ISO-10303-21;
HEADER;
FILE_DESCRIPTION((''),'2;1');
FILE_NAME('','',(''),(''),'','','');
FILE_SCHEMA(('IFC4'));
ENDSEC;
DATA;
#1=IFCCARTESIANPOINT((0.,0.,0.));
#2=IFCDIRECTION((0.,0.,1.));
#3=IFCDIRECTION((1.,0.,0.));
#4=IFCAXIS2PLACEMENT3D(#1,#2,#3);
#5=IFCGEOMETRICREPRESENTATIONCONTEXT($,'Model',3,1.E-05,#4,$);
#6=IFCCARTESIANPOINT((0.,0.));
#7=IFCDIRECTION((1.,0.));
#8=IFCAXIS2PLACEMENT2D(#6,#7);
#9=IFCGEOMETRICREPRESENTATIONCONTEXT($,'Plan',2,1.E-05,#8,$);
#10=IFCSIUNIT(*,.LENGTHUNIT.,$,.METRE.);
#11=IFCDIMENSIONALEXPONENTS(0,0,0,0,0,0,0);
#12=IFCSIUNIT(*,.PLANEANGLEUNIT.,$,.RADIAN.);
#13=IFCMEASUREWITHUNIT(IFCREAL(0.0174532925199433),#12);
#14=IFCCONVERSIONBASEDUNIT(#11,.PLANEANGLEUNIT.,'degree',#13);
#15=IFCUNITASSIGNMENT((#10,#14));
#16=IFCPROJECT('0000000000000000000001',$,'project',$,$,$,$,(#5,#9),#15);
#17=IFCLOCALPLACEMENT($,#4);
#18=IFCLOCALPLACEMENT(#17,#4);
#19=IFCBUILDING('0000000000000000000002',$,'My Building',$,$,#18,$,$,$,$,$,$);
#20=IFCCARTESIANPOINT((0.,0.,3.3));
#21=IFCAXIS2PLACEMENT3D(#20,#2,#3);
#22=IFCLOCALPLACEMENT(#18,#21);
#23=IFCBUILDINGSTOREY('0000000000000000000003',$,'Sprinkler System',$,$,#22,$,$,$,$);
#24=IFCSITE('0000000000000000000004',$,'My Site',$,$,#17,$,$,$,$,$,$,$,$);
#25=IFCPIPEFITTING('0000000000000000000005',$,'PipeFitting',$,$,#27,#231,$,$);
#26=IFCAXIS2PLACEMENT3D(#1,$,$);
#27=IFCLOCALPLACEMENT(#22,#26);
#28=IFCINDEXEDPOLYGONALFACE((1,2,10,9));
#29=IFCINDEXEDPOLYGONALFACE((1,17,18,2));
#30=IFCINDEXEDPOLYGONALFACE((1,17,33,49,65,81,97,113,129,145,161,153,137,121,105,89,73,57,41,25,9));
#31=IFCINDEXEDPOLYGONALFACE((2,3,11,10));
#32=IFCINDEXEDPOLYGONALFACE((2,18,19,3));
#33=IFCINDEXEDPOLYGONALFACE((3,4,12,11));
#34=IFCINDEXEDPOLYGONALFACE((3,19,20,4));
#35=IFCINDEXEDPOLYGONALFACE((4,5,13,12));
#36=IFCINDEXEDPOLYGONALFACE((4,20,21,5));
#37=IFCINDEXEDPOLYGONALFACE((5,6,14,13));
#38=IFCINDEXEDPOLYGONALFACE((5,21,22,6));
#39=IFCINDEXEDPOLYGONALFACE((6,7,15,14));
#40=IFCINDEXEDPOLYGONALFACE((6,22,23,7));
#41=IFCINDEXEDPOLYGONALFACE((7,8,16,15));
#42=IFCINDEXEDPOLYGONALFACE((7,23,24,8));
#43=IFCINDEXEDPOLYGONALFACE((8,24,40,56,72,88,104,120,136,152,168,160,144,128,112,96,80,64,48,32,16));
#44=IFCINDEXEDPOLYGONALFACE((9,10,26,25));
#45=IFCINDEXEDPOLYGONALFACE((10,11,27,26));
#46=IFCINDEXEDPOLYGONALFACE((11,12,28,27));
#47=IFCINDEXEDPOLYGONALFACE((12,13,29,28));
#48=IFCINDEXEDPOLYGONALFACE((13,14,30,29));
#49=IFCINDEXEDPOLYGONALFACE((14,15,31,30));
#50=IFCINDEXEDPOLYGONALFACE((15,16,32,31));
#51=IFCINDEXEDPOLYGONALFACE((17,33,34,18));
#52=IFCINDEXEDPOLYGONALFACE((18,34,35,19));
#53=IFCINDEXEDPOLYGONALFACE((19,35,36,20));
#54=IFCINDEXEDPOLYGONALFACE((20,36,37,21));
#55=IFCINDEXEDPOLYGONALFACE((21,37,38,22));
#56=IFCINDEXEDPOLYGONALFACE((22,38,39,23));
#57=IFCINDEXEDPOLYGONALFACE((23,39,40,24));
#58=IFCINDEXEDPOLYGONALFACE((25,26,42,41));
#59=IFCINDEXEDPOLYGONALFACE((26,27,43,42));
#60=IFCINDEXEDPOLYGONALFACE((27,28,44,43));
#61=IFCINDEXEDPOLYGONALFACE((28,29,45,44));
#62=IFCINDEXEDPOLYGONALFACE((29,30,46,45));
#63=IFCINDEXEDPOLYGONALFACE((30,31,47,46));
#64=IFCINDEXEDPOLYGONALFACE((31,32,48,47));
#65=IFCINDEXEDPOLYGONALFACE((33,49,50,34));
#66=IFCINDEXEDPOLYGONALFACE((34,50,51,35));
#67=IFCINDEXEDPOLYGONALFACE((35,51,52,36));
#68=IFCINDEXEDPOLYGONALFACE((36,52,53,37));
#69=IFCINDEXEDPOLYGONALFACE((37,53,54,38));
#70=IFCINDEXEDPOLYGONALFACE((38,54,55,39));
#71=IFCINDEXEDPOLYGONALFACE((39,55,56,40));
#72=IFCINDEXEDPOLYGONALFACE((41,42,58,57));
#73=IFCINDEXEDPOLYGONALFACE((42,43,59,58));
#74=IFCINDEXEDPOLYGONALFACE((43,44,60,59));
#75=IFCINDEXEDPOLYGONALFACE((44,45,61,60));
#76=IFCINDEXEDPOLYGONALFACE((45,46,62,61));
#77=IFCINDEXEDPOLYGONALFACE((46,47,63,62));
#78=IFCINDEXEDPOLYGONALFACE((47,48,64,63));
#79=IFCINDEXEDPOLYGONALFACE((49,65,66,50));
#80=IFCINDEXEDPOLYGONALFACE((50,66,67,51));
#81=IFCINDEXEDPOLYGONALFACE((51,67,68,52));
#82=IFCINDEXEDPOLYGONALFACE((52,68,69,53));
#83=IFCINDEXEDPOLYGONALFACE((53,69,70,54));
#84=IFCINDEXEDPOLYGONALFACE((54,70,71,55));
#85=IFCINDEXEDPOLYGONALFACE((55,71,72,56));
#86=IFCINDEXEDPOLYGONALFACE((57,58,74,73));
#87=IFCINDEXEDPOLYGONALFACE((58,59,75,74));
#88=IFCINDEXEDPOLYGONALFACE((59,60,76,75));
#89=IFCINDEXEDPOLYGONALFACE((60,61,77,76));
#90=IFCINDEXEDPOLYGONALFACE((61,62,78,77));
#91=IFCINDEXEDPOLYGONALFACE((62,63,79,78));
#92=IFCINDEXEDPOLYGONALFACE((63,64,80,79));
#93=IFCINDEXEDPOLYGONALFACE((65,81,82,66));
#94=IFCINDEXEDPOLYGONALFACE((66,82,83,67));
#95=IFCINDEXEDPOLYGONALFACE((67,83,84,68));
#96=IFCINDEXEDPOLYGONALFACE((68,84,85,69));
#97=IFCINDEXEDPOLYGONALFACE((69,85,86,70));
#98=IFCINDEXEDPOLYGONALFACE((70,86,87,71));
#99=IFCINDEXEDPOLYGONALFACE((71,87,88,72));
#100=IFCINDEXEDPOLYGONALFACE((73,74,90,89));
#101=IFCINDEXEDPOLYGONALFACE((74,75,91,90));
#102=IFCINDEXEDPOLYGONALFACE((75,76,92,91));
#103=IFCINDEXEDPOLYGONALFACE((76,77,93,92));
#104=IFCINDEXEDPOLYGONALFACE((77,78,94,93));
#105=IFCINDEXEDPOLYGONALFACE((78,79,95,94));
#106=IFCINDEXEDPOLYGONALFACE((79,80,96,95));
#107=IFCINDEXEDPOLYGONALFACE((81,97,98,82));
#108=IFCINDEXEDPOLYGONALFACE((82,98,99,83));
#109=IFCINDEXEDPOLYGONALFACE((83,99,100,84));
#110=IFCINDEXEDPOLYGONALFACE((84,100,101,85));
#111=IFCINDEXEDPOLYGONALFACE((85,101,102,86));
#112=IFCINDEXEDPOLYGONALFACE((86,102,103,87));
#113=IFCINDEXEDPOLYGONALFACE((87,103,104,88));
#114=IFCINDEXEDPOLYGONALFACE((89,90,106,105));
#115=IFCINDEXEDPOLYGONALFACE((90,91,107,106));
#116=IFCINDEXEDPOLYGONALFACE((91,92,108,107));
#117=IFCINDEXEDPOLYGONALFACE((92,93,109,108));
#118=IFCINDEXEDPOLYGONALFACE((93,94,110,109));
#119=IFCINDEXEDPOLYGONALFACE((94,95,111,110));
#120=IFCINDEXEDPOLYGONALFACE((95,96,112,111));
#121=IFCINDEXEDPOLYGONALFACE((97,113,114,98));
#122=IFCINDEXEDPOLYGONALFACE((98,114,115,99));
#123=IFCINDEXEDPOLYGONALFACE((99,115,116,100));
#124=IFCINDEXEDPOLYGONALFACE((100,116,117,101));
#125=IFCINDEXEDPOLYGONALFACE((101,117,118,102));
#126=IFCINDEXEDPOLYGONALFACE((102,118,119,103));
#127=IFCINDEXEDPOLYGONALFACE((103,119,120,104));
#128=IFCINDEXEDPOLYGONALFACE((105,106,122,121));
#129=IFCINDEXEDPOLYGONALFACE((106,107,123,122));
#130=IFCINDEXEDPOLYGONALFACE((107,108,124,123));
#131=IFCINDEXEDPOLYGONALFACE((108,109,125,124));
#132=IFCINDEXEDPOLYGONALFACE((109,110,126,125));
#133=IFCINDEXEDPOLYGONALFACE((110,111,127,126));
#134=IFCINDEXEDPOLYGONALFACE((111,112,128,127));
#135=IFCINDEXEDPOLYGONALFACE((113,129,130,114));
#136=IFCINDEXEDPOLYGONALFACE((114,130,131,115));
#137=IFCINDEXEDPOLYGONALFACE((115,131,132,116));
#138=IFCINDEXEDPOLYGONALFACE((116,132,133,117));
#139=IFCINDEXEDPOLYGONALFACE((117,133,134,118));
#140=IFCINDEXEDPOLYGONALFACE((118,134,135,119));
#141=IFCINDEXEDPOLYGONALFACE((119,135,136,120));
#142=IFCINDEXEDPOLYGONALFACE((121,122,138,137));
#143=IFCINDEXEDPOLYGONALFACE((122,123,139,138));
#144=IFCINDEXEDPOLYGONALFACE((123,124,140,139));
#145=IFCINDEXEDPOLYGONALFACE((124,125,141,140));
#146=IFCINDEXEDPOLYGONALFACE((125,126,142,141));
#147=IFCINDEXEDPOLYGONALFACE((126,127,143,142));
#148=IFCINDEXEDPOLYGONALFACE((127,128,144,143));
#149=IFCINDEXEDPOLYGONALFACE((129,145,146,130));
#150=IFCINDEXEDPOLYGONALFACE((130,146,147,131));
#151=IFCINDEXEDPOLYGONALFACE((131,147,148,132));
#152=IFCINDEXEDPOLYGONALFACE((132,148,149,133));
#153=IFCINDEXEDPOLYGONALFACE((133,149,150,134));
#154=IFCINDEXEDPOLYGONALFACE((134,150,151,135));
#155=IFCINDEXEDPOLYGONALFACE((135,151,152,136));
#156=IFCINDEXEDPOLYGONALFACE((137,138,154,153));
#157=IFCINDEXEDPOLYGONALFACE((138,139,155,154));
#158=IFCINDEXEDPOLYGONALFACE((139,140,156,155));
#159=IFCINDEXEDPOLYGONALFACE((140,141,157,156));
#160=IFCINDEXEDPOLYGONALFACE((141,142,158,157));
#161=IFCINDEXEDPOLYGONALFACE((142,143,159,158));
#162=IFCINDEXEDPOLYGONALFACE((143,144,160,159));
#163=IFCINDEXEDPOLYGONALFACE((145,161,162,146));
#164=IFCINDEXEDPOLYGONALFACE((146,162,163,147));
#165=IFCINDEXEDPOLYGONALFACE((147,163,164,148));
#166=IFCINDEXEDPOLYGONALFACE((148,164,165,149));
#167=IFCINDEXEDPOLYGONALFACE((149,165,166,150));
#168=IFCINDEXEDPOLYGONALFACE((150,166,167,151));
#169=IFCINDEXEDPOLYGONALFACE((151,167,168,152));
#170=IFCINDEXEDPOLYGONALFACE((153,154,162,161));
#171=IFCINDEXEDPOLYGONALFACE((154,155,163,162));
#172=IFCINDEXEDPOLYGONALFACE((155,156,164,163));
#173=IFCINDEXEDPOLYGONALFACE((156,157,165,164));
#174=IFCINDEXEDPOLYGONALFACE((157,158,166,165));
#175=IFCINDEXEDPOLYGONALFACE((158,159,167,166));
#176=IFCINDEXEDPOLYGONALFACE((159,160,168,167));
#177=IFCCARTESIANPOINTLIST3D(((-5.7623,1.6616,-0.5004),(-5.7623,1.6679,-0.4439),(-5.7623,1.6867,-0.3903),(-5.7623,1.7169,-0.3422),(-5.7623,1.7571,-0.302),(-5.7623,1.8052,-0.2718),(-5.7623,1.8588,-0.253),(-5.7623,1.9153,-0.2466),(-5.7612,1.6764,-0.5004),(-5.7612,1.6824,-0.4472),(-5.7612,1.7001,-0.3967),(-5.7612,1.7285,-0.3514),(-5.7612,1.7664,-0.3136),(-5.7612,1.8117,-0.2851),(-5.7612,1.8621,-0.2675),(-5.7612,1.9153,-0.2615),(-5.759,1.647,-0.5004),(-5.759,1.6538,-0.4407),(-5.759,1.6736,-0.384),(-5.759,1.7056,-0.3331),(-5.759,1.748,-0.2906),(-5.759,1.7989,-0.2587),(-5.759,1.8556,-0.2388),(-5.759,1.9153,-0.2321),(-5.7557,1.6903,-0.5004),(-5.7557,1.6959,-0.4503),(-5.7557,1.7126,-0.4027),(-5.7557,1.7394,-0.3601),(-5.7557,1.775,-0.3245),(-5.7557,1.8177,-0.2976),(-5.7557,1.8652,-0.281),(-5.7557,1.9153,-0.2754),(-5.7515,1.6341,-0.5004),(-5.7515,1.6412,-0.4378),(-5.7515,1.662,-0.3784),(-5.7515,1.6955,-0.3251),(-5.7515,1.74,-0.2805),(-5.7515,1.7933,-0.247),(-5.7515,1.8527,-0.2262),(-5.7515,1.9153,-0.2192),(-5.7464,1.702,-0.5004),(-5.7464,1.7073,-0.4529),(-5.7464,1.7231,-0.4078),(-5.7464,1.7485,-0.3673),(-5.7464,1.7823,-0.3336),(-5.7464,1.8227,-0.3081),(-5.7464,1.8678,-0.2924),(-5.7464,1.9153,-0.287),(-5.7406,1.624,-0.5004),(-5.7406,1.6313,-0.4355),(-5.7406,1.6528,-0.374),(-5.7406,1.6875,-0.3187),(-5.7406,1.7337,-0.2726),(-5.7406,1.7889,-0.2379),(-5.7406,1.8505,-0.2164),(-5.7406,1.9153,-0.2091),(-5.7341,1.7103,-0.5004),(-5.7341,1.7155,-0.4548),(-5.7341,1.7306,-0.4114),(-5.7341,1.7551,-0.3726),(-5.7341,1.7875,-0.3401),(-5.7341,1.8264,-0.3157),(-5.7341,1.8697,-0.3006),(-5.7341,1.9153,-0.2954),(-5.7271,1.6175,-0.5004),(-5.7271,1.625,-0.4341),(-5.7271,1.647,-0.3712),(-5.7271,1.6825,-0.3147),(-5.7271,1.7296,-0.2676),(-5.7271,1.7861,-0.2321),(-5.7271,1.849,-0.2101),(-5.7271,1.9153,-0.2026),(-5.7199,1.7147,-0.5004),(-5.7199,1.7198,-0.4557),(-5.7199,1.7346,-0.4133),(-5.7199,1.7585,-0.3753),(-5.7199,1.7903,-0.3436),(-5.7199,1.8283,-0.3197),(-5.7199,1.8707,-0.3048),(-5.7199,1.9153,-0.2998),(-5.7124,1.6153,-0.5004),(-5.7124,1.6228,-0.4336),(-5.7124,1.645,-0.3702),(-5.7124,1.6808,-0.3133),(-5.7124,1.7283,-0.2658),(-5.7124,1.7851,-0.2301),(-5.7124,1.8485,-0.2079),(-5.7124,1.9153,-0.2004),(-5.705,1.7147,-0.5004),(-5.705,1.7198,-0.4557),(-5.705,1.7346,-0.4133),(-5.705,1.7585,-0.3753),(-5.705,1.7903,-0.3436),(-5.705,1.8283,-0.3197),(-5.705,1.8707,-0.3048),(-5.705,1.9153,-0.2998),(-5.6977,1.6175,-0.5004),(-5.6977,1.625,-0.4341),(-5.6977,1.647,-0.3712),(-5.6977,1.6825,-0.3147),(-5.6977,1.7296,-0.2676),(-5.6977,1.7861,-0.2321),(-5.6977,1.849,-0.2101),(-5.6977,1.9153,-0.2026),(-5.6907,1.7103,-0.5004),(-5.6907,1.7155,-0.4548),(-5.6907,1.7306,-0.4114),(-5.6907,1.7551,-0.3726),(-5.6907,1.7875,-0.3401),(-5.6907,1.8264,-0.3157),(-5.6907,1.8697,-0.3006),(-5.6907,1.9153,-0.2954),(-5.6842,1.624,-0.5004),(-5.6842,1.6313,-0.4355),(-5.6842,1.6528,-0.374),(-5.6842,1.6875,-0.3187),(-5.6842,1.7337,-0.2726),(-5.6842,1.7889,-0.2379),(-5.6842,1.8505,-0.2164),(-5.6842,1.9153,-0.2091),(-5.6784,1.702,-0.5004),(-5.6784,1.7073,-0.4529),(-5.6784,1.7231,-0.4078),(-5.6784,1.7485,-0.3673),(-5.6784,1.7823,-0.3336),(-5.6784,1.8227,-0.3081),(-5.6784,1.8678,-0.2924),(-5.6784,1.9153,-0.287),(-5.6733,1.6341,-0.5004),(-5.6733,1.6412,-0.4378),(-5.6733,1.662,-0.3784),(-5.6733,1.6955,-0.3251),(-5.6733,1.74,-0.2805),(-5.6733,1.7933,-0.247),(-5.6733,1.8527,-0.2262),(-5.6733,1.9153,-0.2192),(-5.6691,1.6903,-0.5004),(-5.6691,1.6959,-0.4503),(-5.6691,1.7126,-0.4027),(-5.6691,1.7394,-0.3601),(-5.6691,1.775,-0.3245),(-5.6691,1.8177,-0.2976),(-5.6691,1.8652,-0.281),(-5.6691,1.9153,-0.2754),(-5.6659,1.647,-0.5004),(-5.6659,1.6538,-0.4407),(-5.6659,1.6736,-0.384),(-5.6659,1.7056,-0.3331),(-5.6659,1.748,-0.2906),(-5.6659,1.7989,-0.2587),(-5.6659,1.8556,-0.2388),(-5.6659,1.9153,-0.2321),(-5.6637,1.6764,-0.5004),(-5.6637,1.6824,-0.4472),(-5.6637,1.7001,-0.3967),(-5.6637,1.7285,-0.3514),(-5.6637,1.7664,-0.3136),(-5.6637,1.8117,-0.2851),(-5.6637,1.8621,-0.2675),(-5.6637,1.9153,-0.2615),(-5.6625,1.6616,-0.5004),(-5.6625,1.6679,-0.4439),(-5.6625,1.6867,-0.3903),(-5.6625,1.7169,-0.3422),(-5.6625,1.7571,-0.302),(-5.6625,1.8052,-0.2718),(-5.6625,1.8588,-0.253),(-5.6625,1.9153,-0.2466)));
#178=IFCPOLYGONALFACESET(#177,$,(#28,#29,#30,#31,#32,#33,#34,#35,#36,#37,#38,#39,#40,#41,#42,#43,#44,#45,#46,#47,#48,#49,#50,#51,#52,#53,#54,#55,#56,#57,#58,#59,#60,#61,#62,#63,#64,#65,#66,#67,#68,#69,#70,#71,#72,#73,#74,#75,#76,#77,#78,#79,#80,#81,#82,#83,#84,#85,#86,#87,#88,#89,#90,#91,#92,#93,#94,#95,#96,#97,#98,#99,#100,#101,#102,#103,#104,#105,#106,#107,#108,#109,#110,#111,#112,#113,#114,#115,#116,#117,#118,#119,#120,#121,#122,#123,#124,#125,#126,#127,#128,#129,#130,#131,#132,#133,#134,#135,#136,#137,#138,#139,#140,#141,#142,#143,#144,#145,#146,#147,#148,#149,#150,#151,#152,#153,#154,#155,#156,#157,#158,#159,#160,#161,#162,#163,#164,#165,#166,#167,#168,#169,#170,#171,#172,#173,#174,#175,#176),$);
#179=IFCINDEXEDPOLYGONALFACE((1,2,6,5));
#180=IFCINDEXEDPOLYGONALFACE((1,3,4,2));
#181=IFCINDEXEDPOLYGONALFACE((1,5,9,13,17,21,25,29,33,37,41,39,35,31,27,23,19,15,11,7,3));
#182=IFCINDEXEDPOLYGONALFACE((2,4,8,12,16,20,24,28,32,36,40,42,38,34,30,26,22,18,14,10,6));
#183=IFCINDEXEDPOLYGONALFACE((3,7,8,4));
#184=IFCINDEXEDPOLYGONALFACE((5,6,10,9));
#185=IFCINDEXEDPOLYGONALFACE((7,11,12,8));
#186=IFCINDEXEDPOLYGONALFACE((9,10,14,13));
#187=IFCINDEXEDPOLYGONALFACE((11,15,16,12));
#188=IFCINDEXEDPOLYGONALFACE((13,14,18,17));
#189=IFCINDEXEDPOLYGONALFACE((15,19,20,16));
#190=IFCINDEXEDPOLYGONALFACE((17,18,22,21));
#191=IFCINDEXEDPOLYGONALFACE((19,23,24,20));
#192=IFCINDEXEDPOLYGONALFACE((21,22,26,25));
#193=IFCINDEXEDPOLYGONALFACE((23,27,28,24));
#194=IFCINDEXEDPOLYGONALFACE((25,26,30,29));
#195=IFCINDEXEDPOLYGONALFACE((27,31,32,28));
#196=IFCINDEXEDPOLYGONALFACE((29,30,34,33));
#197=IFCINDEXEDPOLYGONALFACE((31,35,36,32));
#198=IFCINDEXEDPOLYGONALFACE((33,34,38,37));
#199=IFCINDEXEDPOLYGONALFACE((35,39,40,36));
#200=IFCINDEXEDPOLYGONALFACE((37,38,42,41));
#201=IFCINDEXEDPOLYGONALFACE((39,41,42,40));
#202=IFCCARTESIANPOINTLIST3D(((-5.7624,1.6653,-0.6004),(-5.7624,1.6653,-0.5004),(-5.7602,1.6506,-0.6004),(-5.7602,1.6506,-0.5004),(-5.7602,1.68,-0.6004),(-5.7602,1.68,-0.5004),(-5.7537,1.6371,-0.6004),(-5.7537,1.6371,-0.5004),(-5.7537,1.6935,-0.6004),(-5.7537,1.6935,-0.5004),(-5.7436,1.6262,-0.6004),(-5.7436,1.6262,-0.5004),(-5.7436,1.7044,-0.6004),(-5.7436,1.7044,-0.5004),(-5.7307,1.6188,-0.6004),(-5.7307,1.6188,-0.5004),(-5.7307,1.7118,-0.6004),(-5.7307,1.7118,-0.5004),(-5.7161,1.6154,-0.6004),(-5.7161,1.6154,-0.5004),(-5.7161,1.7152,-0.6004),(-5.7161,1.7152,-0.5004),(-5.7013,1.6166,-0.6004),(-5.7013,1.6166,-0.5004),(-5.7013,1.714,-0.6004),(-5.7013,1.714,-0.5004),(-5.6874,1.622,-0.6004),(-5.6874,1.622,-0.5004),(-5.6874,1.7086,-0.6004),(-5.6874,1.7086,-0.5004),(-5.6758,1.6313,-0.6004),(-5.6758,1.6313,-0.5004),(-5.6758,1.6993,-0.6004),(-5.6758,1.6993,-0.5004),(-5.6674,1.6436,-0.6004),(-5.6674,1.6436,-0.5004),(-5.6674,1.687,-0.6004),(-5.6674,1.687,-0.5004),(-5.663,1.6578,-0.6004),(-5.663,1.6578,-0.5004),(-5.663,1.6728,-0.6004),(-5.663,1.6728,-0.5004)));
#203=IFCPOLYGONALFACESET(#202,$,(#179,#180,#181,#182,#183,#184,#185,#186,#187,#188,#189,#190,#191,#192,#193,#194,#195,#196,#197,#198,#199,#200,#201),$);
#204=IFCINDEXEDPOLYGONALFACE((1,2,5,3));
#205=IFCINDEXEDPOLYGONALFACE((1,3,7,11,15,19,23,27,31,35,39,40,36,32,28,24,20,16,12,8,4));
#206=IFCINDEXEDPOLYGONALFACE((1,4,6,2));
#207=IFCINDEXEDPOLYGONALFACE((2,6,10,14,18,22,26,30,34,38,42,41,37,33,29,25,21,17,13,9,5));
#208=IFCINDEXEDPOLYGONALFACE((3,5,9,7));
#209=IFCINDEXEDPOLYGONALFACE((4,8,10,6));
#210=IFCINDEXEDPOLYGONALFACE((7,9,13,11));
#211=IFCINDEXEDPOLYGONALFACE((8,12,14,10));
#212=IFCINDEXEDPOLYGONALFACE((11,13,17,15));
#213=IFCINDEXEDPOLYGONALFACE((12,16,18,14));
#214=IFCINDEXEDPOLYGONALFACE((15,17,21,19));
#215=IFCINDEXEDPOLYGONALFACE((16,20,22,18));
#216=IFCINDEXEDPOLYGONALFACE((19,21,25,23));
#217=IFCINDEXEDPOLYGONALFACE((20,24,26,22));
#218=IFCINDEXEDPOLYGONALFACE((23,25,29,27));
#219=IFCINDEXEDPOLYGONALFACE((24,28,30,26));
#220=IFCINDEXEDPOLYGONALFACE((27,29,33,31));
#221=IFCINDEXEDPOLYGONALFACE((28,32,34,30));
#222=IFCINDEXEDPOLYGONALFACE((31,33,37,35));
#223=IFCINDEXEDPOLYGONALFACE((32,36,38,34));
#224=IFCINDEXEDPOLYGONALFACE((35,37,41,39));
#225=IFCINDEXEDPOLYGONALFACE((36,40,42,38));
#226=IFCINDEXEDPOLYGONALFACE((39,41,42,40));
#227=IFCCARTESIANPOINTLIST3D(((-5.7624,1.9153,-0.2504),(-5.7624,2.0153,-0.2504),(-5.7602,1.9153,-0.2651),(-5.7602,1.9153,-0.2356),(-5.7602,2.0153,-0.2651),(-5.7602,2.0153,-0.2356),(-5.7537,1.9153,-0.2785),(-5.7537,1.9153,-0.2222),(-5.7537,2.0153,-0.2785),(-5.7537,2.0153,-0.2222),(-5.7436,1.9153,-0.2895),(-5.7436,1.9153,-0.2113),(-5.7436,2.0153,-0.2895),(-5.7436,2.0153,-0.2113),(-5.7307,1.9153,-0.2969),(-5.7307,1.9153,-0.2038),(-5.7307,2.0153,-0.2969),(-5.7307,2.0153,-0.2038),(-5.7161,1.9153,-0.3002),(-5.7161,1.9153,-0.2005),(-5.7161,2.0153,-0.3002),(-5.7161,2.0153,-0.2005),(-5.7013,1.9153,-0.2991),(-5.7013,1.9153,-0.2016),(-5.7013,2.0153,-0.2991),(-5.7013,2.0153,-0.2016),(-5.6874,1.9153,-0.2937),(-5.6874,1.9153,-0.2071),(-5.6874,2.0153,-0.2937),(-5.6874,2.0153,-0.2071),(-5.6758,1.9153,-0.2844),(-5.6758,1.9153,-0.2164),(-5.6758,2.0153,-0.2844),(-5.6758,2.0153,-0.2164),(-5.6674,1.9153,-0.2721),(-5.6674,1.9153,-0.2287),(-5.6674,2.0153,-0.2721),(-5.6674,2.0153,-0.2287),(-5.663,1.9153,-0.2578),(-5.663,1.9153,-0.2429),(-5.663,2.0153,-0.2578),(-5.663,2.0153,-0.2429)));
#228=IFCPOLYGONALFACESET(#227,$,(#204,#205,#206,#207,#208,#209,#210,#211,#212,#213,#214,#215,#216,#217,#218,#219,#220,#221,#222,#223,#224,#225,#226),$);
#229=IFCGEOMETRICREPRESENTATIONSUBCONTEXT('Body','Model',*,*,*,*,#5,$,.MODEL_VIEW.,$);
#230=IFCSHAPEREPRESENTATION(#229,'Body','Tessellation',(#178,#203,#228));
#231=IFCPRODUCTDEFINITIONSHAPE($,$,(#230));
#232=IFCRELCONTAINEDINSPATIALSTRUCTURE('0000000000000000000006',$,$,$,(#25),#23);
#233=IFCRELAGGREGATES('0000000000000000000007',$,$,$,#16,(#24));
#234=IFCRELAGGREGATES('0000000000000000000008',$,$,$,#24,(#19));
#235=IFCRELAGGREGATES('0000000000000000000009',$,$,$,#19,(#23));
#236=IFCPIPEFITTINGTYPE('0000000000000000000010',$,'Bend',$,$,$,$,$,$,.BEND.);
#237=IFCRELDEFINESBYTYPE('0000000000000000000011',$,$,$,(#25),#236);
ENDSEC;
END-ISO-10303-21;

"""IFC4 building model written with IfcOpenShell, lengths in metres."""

from ifc_helpers import new_model, entity, si_unit, converted_unit, frame, origin_with_axes, origin_2d_with_axis, place, context, subcontext, project, spatial, circle, extrude, source, transform, mapped, type_object, type_shapes, element, save


model = new_model("IFC4")

# Units and contexts
model_context = context("Model", 3, precision=1e-05, world=origin_with_axes())
plan_context = context("Plan", 2, precision=1e-05, world=origin_2d_with_axis())
body_context = subcontext(model_context, "Body", "Model", "MODEL_VIEW")
ifc_project = project(units=[si_unit("LENGTHUNIT", "METRE"), converted_unit("PLANEANGLEUNIT", "degree", entity("IfcReal", 0.0174532925199433), si_unit("PLANEANGLEUNIT", "RADIAN"), dimensions=[0, 0, 0, 0, 0, 0, 0])], contexts=[model_context, plan_context])

# Site, building, storey
site_placement = place(None, origin_with_axes())
site = spatial("IfcSite", under=ifc_project, at=site_placement, Name="My Site")
building_placement = place(site_placement, origin_with_axes())
building = spatial("IfcBuilding", under=site, at=building_placement, Name="My Building")
storey_placement = place(building_placement, frame((0.0, 0.0, 3.3), z_axis=(0.0, 0.0, 1.0), x_axis=(1.0, 0.0, 0.0)))
storey = spatial("IfcBuildingStorey", under=building, at=storey_placement, Name="Sprinkler System")

# Pipe fitting
pipe_fitting_type_1 = type_object("IfcPipeFittingType", Name="Bend", PredefinedType="BEND")
shared_shape_1 = source(origin_with_axes(), body_context, "Body", "SolidModel", [
    entity("IfcSweptDiskSolid", entity("IfcIndexedPolyCurve", entity("IfcCartesianPointList3D", [[0.0, 0.0, -0.1], [0.0, 0.0732, -0.2768], [0.0, 0.25, -0.35]]), [entity("IfcArcIndex", [1, 2, 3])]), 0.05),
    extrude(circle(Radius=0.05), origin_with_axes(), (0.0, 0.0, -1.0), 0.1),
    extrude(circle(Radius=0.05), frame((0.0, 0.25, -0.35), z_axis=(0.0, 1.0, 0.0), x_axis=(1.0, 0.0, 0.0)), (0.0, 0.0, 1.0), 0.1),
])
type_shapes(pipe_fitting_type_1, [shared_shape_1])
for number, where, z_axis, x_axis, name in (
    (1, (-5.7124, 1.6653, -0.6004), (0.0, 0.0, -1.0), (-1.0, 0.0, 0.0), "PipeFitting"),
):
    element("IfcPipeFitting", number, at=place(storey_placement, frame(where, z_axis=z_axis, x_axis=x_axis)), inside=storey, type_object=pipe_fitting_type_1, Name=name, context=body_context, shape_type="MappedRepresentation", body=[
        mapped(shared_shape_1, transform((0.0, 0.0, 0.0), x_axis=(1.0, 0.0, 0.0), y_axis=(0.0, 1.0, 0.0), z_axis=(0.0, 0.0, 1.0), scale=1.0)),
    ])

save(model, "model.ifc")
